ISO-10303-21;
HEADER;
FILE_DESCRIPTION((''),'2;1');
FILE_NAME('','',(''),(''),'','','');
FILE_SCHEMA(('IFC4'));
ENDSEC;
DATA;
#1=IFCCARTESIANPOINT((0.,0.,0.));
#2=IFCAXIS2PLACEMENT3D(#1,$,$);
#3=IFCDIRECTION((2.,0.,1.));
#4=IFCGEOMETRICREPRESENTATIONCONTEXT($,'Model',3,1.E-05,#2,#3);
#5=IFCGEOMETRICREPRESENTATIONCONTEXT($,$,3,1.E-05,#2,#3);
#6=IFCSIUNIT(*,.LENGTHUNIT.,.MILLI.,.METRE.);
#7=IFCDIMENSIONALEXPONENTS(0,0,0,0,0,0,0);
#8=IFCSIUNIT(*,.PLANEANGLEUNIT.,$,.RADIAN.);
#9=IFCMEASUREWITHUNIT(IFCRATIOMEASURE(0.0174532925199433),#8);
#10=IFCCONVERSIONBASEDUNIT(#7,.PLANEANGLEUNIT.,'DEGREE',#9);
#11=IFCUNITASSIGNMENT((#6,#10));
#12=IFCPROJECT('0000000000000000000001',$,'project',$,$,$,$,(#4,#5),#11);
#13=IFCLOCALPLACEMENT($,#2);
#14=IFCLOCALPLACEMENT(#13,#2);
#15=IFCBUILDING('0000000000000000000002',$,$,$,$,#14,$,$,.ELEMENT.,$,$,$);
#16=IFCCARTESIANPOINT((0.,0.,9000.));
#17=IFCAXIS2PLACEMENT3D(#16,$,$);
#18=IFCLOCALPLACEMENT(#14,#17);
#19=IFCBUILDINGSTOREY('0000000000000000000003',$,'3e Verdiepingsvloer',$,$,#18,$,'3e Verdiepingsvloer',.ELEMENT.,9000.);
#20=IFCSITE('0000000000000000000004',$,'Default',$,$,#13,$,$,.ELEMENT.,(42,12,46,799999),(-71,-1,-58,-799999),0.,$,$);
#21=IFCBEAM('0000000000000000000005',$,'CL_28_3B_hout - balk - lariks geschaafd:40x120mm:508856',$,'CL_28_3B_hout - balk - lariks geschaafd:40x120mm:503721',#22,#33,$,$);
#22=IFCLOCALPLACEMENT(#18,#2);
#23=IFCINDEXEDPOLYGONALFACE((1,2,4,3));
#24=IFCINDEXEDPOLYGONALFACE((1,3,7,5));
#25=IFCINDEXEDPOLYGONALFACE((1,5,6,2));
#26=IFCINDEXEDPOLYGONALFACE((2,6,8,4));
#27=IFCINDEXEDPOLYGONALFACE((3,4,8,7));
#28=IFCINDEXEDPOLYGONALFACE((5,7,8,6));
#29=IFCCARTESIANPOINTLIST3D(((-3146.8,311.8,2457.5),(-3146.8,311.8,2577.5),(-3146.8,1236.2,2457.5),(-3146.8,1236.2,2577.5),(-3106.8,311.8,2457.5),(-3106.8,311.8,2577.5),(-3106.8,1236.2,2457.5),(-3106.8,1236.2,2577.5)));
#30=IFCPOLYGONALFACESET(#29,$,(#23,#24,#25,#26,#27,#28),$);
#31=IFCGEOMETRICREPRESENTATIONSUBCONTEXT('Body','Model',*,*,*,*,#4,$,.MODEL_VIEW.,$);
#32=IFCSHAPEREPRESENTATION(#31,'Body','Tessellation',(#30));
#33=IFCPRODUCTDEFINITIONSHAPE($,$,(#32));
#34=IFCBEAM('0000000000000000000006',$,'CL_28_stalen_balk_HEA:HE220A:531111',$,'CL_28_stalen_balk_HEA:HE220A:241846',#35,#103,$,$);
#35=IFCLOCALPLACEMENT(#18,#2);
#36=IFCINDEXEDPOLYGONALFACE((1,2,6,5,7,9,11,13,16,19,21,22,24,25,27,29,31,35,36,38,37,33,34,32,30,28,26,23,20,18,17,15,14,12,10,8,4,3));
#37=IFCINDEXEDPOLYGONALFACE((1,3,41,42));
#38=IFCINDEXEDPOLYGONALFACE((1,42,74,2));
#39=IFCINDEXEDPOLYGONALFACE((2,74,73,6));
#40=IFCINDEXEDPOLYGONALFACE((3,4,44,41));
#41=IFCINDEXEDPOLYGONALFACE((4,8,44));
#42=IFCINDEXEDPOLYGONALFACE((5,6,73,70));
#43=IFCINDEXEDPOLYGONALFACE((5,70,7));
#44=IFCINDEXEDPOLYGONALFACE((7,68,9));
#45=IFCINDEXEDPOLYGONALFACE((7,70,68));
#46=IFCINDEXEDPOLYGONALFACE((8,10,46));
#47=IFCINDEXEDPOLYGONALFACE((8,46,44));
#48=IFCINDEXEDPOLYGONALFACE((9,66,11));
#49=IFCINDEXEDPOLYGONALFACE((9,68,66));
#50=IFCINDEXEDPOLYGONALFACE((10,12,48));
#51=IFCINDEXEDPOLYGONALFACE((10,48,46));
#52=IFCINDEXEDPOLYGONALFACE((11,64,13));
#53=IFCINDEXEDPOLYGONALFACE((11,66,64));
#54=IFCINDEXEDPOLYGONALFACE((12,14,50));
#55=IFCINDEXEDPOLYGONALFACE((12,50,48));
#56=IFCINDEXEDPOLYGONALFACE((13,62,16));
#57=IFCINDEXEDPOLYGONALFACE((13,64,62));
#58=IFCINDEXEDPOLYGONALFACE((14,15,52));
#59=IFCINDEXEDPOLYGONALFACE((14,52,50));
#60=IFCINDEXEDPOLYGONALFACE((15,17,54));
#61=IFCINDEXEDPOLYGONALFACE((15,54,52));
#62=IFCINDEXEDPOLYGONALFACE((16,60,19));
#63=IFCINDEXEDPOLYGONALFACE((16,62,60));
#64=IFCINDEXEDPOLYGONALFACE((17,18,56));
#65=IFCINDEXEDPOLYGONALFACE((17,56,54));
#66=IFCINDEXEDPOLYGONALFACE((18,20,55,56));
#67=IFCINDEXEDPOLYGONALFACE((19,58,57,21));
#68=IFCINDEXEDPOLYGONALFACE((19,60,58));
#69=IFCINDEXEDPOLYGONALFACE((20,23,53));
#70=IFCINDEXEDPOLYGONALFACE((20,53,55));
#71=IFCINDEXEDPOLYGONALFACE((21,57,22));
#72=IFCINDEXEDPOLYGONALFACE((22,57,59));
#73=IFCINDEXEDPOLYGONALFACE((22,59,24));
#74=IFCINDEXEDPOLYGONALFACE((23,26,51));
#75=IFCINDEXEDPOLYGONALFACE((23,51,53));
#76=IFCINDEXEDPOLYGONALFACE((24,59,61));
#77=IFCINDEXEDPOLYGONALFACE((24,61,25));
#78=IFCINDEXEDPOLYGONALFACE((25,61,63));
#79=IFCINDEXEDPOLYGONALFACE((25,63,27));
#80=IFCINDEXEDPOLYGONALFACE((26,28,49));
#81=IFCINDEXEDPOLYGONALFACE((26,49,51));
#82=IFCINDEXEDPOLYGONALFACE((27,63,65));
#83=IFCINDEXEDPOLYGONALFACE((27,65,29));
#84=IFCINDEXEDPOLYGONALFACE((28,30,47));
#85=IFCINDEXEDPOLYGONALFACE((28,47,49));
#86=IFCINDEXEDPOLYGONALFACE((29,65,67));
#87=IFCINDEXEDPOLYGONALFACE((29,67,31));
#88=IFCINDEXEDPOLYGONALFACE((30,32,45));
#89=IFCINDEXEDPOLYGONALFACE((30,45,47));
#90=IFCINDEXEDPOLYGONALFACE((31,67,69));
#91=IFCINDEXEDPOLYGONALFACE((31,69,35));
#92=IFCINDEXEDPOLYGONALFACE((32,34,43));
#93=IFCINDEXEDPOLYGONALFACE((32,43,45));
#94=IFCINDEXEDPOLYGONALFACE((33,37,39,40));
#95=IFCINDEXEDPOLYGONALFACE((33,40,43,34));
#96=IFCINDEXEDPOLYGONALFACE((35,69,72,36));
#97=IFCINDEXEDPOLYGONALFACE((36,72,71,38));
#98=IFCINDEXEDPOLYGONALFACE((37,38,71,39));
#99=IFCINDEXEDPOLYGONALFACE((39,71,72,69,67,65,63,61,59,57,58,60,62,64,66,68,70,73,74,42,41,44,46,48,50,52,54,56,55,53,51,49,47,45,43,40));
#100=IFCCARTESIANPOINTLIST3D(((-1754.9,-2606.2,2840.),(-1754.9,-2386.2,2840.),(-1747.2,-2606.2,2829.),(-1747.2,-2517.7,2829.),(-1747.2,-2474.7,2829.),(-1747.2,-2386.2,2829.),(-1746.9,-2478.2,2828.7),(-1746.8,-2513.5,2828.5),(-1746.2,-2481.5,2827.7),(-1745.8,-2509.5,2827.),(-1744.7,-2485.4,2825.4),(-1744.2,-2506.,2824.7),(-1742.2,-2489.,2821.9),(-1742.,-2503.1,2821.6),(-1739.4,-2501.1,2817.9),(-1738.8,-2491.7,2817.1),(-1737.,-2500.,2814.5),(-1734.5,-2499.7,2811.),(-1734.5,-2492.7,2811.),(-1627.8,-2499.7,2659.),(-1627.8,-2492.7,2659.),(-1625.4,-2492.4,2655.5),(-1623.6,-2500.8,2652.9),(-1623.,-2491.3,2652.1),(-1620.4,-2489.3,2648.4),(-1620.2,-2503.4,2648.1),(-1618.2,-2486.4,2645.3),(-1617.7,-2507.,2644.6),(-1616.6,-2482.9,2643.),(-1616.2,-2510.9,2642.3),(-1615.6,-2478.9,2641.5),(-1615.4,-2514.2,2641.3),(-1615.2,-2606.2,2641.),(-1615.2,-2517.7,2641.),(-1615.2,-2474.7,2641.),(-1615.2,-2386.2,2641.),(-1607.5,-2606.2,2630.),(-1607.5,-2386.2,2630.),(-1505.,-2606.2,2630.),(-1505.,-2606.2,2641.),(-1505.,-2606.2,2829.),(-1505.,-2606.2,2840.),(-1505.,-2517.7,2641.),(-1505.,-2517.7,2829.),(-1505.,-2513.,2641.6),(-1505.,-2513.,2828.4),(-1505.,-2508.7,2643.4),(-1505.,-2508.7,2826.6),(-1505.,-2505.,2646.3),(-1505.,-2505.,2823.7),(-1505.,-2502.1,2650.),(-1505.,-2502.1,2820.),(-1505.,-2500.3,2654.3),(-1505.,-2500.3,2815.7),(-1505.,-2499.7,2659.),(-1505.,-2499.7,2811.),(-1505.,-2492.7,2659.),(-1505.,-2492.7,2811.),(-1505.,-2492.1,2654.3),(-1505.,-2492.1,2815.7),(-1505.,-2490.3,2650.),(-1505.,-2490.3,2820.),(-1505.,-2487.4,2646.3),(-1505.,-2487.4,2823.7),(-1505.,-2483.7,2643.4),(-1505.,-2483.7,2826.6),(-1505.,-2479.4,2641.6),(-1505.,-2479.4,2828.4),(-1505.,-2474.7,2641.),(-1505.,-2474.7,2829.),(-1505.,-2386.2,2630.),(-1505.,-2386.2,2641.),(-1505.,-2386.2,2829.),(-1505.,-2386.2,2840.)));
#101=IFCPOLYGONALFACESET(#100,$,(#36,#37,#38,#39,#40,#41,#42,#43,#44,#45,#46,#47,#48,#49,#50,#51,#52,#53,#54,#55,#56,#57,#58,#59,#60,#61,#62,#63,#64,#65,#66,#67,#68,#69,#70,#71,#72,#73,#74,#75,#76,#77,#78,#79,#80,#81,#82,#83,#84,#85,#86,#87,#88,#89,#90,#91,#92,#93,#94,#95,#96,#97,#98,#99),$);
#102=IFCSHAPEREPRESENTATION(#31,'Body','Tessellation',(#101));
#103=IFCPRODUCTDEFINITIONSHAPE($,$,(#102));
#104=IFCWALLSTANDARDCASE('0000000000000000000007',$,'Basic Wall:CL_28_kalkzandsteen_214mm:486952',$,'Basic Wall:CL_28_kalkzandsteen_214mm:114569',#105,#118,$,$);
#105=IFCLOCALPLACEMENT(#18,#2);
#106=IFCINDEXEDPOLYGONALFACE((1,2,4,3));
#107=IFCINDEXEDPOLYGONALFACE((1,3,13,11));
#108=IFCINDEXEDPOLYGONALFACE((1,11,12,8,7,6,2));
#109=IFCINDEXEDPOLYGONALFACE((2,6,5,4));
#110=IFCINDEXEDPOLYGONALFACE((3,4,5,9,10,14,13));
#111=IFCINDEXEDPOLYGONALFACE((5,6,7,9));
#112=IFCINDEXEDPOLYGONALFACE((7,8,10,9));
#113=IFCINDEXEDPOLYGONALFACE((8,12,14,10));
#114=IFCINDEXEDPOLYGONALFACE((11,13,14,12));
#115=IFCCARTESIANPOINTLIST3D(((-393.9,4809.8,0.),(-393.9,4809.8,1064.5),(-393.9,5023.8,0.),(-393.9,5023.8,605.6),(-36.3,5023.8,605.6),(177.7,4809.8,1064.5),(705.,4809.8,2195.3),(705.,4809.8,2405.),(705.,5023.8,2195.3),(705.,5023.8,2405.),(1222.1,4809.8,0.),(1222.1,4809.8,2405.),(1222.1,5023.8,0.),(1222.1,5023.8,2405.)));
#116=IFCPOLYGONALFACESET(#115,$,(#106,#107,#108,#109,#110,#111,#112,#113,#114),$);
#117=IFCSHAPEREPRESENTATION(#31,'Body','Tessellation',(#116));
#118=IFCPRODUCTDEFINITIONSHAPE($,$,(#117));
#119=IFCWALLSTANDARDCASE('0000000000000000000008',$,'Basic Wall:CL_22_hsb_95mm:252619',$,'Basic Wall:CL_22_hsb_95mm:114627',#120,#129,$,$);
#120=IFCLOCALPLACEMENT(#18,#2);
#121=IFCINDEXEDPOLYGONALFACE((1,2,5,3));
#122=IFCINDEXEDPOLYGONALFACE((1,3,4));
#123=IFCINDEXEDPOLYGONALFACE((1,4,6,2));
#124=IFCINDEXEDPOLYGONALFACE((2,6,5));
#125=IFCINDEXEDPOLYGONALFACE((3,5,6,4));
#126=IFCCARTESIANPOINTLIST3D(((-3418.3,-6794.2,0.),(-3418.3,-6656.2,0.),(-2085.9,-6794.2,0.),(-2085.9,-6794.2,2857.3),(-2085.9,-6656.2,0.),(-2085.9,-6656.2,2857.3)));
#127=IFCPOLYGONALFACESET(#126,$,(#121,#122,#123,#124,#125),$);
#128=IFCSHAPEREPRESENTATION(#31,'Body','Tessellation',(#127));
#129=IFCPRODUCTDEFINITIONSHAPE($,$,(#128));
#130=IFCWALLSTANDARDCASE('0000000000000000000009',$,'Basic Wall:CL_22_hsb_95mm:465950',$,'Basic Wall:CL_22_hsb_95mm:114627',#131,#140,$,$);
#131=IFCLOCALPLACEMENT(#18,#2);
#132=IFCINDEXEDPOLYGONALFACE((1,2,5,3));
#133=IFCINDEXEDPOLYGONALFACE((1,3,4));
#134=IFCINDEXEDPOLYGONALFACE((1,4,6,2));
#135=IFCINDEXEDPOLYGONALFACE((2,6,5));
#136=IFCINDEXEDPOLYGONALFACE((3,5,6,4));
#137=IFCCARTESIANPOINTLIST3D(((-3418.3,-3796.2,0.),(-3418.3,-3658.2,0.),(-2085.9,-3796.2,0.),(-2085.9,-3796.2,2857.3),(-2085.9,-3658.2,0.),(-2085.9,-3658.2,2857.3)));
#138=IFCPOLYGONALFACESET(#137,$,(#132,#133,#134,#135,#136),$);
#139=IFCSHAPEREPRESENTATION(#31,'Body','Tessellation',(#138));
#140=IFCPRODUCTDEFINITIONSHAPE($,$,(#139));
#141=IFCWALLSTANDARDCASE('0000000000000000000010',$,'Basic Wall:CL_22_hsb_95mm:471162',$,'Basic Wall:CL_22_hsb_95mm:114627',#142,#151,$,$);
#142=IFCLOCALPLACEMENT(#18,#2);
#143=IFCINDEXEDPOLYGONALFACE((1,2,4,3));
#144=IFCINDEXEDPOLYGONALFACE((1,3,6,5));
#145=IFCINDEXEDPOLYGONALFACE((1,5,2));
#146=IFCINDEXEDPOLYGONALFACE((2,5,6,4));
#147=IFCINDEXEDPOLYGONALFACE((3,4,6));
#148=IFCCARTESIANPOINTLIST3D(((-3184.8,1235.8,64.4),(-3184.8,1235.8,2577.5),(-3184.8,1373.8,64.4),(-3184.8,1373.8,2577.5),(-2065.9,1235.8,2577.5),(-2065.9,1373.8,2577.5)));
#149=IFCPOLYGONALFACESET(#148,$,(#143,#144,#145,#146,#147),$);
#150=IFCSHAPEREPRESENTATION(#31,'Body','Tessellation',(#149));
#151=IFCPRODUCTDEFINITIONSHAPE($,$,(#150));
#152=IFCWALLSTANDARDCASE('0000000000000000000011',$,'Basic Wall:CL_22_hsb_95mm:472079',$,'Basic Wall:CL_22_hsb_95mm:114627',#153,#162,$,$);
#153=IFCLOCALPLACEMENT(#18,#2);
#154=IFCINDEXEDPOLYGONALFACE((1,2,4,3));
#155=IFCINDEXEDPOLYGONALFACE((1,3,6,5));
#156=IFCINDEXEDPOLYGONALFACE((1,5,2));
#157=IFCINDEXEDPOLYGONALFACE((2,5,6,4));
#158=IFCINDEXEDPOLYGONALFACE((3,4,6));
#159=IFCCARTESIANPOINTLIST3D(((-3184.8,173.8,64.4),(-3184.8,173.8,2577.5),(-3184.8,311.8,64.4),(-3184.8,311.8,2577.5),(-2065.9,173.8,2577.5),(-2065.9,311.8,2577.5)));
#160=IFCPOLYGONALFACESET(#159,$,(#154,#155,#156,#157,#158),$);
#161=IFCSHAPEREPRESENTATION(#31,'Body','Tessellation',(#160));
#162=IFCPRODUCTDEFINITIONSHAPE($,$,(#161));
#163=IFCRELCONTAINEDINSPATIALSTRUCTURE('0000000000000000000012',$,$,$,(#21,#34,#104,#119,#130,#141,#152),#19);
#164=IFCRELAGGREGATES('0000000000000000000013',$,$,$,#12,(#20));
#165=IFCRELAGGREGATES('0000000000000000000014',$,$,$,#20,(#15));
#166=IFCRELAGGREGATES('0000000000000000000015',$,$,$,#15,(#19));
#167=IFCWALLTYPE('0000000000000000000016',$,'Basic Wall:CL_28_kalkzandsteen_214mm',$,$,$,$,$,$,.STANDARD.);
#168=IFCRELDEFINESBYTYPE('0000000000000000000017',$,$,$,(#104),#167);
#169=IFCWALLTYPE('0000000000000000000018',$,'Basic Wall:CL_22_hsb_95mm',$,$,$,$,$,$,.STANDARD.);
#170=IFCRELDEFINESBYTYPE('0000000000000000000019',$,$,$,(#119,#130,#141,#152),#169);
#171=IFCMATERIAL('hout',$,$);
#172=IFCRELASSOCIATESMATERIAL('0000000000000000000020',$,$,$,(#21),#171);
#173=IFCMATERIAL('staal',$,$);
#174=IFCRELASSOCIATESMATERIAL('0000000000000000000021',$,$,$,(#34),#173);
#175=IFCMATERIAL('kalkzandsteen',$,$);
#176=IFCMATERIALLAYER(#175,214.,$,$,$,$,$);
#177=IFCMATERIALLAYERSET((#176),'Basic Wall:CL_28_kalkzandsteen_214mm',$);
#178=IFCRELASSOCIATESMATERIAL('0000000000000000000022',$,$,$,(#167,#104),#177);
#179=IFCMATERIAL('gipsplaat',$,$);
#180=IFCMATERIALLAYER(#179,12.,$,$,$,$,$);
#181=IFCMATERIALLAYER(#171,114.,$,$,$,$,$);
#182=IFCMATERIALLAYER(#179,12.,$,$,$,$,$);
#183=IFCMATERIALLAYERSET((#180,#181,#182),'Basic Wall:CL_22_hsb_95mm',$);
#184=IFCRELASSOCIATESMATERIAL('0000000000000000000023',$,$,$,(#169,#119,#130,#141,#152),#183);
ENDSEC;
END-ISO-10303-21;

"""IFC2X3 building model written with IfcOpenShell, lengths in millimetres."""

from ifc_helpers import new_model, entity, si_unit, converted_unit, direction, frame, frame_2d, origin, origin_2d_with_axis, place, context, subcontext, project, spatial, polyline, rectangle, i_section, extrude, clip, halfspace, bounded_halfspace, material, layer, layer_set, layer_usage, type_object, element, save


model = new_model("IFC2X3")

# Units and contexts
model_context = context("Model", 3, precision=1e-05, world=origin(), true_north=direction((2.0, 0.0, 1.0)))
context_of_model = context(None, 3, precision=1e-05, world=origin(), true_north=direction((2.0, 0.0, 1.0)))
body_context = subcontext(model_context, "Body", "Model", "MODEL_VIEW")
ifc_project = project(units=[si_unit("LENGTHUNIT", "METRE", prefix="MILLI"), converted_unit("PLANEANGLEUNIT", "DEGREE", entity("IfcRatioMeasure", 0.0174532925199433), si_unit("PLANEANGLEUNIT", "RADIAN"), dimensions=[0, 0, 0, 0, 0, 0, 0])], contexts=[model_context, context_of_model])

# Site, building, storey
site_placement = place(None, origin())
site = spatial("IfcSite", under=ifc_project, at=site_placement, Name="Default", CompositionType="ELEMENT", RefLatitude=(42, 12, 46, 799999), RefLongitude=(-71, -1, -58, -799999), RefElevation=0.0)
building_placement = place(site_placement, origin())
building = spatial("IfcBuilding", under=site, at=building_placement, CompositionType="ELEMENT")
storey_placement = place(building_placement, frame((0.0, 0.0, 9000.0)))
storey = spatial("IfcBuildingStorey", under=building, at=storey_placement, Name="3e Verdiepingsvloer", LongName="3e Verdiepingsvloer", CompositionType="ELEMENT", Elevation=9000.0)

# Beams
ifc_material_1 = material(Name="staal")
ifc_material_2 = material(Name="hout")
beam_1_placement = place(storey_placement, frame((-3126.8, 1304.8, 2577.5), z_axis=(0.0, 0.0, 1.0), x_axis=(0.0, -1.0, 0.0)))
element("IfcBeam", 1, at=beam_1_placement, inside=storey, material=ifc_material_2, Name="CL_28_3B_hout - balk - lariks geschaafd:40x120mm:508856", ObjectType="CL_28_3B_hout - balk - lariks geschaafd:40x120mm:503721", context=body_context, shape_type="SweptSolid", body=[
    extrude(rectangle(XDim=120.0, YDim=40.0, at=origin_2d_with_axis()), frame((68.6, 0.0, -60.0), z_axis=(1.0, 0.0, 0.0), x_axis=(0.0, 0.0, -1.0)), (0.0, 0.0, 1.0), 924.4),
])
beam_2_placement = place(storey_placement, frame((-2063.1, -2496.2, 2840.0)))
element("IfcBeam", 2, at=beam_2_placement, inside=storey, material=ifc_material_1, Name="CL_28_stalen_balk_HEA:HE220A:531111", ObjectType="CL_28_stalen_balk_HEA:HE220A:241846", context=body_context, shape_type="Clipping", body=[
    clip(extrude(i_section(OverallWidth=220.0, OverallDepth=210.0, WebThickness=7.0, FlangeThickness=11.0, FilletRadius=18.0, at=frame_2d((0.0, 0.0), x_axis=(0.0, 1.0))), frame((308.2, 0.0, -105.0), z_axis=(1.0, 0.0, 0.0), x_axis=(0.0, 0.0, -1.0)), (0.0, 0.0, 1.0), 249.9), halfspace(frame((300.1, -5856.2, 11.6), z_axis=(-0.818469, 0.0, -0.574551), x_axis=(0.574551, 0.0, -0.818469)), False)),
])

# Walls
ifc_material_3 = material(Name="kalkzandsteen")
ifc_layer_1 = layer(ifc_material_3, 214.0)
ifc_layer_set_1 = layer_set([ifc_layer_1], Name="Basic Wall:CL_28_kalkzandsteen_214mm")
wall_type_1 = type_object("IfcWallType", Name="Basic Wall:CL_28_kalkzandsteen_214mm", PredefinedType="STANDARD", material=ifc_layer_set_1)
ifc_layer_usage_1 = layer_usage(ifc_layer_set_1, "AXIS2", "NEGATIVE", 107.0)
wall_1_placement = place(storey_placement, frame((1222.1, 4916.8, 0.0), z_axis=(0.0, 0.0, 1.0), x_axis=(-1.0, 0.0, 0.0)))
element("IfcWallStandardCase", 3, at=wall_1_placement, inside=storey, type_object=wall_type_1, material=ifc_layer_usage_1, Name="Basic Wall:CL_28_kalkzandsteen_214mm:486952", ObjectType="Basic Wall:CL_28_kalkzandsteen_214mm:114569", context=body_context, shape_type="Clipping", body=[
    clip(clip(clip(extrude(rectangle(XDim=1616.0, YDim=214.0, at=frame_2d((808.0, 0.0), x_axis=(-1.0, 0.0))), origin(), (0.0, 0.0, 1.0), 2640.0), bounded_halfspace(frame((0.0, -107.0, 2405.0), z_axis=(0.0, 0.0, 1.0), x_axis=(-1.0, 0.0, 0.0)), False, frame((0.0, -107.0, 2405.0)), polyline([(0.0, 0.0), (517.1, 0.0), (517.1, 214.0), (0.0, 214.0), (0.0, 0.0)]))), bounded_halfspace(frame((1258.4, -107.0, 605.6), z_axis=(0.0, -0.906308, 0.422618), x_axis=(1.0, 0.0, 0.0)), False, frame((1258.4, -107.0, 605.6)), polyline([(0.0, 0.0), (357.6, 0.0), (357.6, 214.0), (-214.0, 214.0), (0.0, 0.0)]))), bounded_halfspace(frame((517.1, -107.0, 2195.3), z_axis=(0.906308, 0.0, 0.422618), x_axis=(0.0, 1.0, 0.0)), False, frame((517.1, -107.0, 2195.3)), polyline([(0.0, 0.0), (741.3, 0.0), (527.3, 214.0), (0.0, 214.0), (0.0, 0.0)]))),
])
ifc_material_4 = material(Name="gipsplaat")
ifc_layer_2 = layer(ifc_material_4, 12.0)
ifc_layer_3 = layer(ifc_material_2, 114.0)
ifc_layer_4 = layer(ifc_material_4, 12.0)
ifc_layer_set_2 = layer_set([ifc_layer_2, ifc_layer_3, ifc_layer_4], Name="Basic Wall:CL_22_hsb_95mm")
ifc_layer_usage_2 = layer_usage(ifc_layer_set_2, "AXIS2", "NEGATIVE", 69.0)
wall_type_2 = type_object("IfcWallType", Name="Basic Wall:CL_22_hsb_95mm", PredefinedType="STANDARD", material=ifc_layer_set_2)
wall_2_placement = place(storey_placement, frame((-2085.9, -6725.2, 0.0), z_axis=(0.0, 0.0, 1.0), x_axis=(-1.0, 0.0, 0.0)))
element("IfcWallStandardCase", 4, at=wall_2_placement, inside=storey, type_object=wall_type_2, material=ifc_layer_usage_2, Name="Basic Wall:CL_22_hsb_95mm:252619", ObjectType="Basic Wall:CL_22_hsb_95mm:114627", context=body_context, shape_type="Clipping", body=[
    clip(extrude(rectangle(XDim=1332.4, YDim=138.0, at=frame_2d((666.2, 0.0), x_axis=(-1.0, 0.0))), origin(), (0.0, 0.0, 1.0), 2860.0), halfspace(frame((0.0, -69.0, 2857.3), z_axis=(0.906308, 0.0, 0.422618), x_axis=(0.0, 1.0, 0.0)), False)),
])
ifc_layer_usage_3 = layer_usage(ifc_layer_set_2, "AXIS2", "POSITIVE", -69.0)
wall_3_placement = place(storey_placement, frame((-2085.9, -3727.2, 0.0), z_axis=(0.0, 0.0, 1.0), x_axis=(-1.0, 0.0, 0.0)))
element("IfcWallStandardCase", 5, at=wall_3_placement, inside=storey, type_object=wall_type_2, material=ifc_layer_usage_3, Name="Basic Wall:CL_22_hsb_95mm:465950", ObjectType="Basic Wall:CL_22_hsb_95mm:114627", context=body_context, shape_type="Clipping", body=[
    clip(extrude(rectangle(XDim=1332.4, YDim=138.0, at=frame_2d((666.2, 0.0), x_axis=(-1.0, 0.0))), origin(), (0.0, 0.0, 1.0), 2860.0), halfspace(frame((0.0, -69.0, 2857.3), z_axis=(0.906308, 0.0, 0.422618), x_axis=(0.0, 1.0, 0.0)), False)),
])
ifc_layer_usage_4 = layer_usage(ifc_layer_set_2, "AXIS2", "POSITIVE", -69.0)
wall_4_placement = place(storey_placement, frame((-2065.9, 1304.8, 0.0), z_axis=(0.0, 0.0, 1.0), x_axis=(-1.0, 0.0, 0.0)))
element("IfcWallStandardCase", 6, at=wall_4_placement, inside=storey, type_object=wall_type_2, material=ifc_layer_usage_4, Name="Basic Wall:CL_22_hsb_95mm:471162", ObjectType="Basic Wall:CL_22_hsb_95mm:114627", context=body_context, shape_type="Clipping", body=[
    clip(clip(extrude(rectangle(XDim=1118.9, YDim=138.0, at=frame_2d((559.5, 0.0), x_axis=(-1.0, 0.0))), origin(), (0.0, 0.0, 1.0), 2860.0), halfspace(frame((1118.9, -69.0, 64.4), z_axis=(-0.913545, 0.0, -0.406737), x_axis=(0.0, 1.0, 0.0)), False)), halfspace(frame((0.0, -69.0, 2577.5), z_axis=(0.0, 0.0, 1.0), x_axis=(0.0, 1.0, 0.0)), False)),
])
ifc_layer_usage_5 = layer_usage(ifc_layer_set_2, "AXIS2", "POSITIVE", -69.0)
wall_5_placement = place(storey_placement, frame((-2065.9, 242.8, 0.0), z_axis=(0.0, 0.0, 1.0), x_axis=(-1.0, 0.0, 0.0)))
element("IfcWallStandardCase", 7, at=wall_5_placement, inside=storey, type_object=wall_type_2, material=ifc_layer_usage_5, Name="Basic Wall:CL_22_hsb_95mm:472079", ObjectType="Basic Wall:CL_22_hsb_95mm:114627", context=body_context, shape_type="Clipping", body=[
    clip(clip(extrude(rectangle(XDim=1118.9, YDim=138.0, at=frame_2d((559.5, 0.0), x_axis=(-1.0, 0.0))), origin(), (0.0, 0.0, 1.0), 2860.0), halfspace(frame((1118.9, -69.0, 64.4), z_axis=(-0.913545, 0.0, -0.406737), x_axis=(0.0, 1.0, 0.0)), False)), halfspace(frame((0.0, -69.0, 2577.5), z_axis=(0.0, 0.0, 1.0), x_axis=(0.0, 1.0, 0.0)), False)),
])

save(model, "model.ifc")
